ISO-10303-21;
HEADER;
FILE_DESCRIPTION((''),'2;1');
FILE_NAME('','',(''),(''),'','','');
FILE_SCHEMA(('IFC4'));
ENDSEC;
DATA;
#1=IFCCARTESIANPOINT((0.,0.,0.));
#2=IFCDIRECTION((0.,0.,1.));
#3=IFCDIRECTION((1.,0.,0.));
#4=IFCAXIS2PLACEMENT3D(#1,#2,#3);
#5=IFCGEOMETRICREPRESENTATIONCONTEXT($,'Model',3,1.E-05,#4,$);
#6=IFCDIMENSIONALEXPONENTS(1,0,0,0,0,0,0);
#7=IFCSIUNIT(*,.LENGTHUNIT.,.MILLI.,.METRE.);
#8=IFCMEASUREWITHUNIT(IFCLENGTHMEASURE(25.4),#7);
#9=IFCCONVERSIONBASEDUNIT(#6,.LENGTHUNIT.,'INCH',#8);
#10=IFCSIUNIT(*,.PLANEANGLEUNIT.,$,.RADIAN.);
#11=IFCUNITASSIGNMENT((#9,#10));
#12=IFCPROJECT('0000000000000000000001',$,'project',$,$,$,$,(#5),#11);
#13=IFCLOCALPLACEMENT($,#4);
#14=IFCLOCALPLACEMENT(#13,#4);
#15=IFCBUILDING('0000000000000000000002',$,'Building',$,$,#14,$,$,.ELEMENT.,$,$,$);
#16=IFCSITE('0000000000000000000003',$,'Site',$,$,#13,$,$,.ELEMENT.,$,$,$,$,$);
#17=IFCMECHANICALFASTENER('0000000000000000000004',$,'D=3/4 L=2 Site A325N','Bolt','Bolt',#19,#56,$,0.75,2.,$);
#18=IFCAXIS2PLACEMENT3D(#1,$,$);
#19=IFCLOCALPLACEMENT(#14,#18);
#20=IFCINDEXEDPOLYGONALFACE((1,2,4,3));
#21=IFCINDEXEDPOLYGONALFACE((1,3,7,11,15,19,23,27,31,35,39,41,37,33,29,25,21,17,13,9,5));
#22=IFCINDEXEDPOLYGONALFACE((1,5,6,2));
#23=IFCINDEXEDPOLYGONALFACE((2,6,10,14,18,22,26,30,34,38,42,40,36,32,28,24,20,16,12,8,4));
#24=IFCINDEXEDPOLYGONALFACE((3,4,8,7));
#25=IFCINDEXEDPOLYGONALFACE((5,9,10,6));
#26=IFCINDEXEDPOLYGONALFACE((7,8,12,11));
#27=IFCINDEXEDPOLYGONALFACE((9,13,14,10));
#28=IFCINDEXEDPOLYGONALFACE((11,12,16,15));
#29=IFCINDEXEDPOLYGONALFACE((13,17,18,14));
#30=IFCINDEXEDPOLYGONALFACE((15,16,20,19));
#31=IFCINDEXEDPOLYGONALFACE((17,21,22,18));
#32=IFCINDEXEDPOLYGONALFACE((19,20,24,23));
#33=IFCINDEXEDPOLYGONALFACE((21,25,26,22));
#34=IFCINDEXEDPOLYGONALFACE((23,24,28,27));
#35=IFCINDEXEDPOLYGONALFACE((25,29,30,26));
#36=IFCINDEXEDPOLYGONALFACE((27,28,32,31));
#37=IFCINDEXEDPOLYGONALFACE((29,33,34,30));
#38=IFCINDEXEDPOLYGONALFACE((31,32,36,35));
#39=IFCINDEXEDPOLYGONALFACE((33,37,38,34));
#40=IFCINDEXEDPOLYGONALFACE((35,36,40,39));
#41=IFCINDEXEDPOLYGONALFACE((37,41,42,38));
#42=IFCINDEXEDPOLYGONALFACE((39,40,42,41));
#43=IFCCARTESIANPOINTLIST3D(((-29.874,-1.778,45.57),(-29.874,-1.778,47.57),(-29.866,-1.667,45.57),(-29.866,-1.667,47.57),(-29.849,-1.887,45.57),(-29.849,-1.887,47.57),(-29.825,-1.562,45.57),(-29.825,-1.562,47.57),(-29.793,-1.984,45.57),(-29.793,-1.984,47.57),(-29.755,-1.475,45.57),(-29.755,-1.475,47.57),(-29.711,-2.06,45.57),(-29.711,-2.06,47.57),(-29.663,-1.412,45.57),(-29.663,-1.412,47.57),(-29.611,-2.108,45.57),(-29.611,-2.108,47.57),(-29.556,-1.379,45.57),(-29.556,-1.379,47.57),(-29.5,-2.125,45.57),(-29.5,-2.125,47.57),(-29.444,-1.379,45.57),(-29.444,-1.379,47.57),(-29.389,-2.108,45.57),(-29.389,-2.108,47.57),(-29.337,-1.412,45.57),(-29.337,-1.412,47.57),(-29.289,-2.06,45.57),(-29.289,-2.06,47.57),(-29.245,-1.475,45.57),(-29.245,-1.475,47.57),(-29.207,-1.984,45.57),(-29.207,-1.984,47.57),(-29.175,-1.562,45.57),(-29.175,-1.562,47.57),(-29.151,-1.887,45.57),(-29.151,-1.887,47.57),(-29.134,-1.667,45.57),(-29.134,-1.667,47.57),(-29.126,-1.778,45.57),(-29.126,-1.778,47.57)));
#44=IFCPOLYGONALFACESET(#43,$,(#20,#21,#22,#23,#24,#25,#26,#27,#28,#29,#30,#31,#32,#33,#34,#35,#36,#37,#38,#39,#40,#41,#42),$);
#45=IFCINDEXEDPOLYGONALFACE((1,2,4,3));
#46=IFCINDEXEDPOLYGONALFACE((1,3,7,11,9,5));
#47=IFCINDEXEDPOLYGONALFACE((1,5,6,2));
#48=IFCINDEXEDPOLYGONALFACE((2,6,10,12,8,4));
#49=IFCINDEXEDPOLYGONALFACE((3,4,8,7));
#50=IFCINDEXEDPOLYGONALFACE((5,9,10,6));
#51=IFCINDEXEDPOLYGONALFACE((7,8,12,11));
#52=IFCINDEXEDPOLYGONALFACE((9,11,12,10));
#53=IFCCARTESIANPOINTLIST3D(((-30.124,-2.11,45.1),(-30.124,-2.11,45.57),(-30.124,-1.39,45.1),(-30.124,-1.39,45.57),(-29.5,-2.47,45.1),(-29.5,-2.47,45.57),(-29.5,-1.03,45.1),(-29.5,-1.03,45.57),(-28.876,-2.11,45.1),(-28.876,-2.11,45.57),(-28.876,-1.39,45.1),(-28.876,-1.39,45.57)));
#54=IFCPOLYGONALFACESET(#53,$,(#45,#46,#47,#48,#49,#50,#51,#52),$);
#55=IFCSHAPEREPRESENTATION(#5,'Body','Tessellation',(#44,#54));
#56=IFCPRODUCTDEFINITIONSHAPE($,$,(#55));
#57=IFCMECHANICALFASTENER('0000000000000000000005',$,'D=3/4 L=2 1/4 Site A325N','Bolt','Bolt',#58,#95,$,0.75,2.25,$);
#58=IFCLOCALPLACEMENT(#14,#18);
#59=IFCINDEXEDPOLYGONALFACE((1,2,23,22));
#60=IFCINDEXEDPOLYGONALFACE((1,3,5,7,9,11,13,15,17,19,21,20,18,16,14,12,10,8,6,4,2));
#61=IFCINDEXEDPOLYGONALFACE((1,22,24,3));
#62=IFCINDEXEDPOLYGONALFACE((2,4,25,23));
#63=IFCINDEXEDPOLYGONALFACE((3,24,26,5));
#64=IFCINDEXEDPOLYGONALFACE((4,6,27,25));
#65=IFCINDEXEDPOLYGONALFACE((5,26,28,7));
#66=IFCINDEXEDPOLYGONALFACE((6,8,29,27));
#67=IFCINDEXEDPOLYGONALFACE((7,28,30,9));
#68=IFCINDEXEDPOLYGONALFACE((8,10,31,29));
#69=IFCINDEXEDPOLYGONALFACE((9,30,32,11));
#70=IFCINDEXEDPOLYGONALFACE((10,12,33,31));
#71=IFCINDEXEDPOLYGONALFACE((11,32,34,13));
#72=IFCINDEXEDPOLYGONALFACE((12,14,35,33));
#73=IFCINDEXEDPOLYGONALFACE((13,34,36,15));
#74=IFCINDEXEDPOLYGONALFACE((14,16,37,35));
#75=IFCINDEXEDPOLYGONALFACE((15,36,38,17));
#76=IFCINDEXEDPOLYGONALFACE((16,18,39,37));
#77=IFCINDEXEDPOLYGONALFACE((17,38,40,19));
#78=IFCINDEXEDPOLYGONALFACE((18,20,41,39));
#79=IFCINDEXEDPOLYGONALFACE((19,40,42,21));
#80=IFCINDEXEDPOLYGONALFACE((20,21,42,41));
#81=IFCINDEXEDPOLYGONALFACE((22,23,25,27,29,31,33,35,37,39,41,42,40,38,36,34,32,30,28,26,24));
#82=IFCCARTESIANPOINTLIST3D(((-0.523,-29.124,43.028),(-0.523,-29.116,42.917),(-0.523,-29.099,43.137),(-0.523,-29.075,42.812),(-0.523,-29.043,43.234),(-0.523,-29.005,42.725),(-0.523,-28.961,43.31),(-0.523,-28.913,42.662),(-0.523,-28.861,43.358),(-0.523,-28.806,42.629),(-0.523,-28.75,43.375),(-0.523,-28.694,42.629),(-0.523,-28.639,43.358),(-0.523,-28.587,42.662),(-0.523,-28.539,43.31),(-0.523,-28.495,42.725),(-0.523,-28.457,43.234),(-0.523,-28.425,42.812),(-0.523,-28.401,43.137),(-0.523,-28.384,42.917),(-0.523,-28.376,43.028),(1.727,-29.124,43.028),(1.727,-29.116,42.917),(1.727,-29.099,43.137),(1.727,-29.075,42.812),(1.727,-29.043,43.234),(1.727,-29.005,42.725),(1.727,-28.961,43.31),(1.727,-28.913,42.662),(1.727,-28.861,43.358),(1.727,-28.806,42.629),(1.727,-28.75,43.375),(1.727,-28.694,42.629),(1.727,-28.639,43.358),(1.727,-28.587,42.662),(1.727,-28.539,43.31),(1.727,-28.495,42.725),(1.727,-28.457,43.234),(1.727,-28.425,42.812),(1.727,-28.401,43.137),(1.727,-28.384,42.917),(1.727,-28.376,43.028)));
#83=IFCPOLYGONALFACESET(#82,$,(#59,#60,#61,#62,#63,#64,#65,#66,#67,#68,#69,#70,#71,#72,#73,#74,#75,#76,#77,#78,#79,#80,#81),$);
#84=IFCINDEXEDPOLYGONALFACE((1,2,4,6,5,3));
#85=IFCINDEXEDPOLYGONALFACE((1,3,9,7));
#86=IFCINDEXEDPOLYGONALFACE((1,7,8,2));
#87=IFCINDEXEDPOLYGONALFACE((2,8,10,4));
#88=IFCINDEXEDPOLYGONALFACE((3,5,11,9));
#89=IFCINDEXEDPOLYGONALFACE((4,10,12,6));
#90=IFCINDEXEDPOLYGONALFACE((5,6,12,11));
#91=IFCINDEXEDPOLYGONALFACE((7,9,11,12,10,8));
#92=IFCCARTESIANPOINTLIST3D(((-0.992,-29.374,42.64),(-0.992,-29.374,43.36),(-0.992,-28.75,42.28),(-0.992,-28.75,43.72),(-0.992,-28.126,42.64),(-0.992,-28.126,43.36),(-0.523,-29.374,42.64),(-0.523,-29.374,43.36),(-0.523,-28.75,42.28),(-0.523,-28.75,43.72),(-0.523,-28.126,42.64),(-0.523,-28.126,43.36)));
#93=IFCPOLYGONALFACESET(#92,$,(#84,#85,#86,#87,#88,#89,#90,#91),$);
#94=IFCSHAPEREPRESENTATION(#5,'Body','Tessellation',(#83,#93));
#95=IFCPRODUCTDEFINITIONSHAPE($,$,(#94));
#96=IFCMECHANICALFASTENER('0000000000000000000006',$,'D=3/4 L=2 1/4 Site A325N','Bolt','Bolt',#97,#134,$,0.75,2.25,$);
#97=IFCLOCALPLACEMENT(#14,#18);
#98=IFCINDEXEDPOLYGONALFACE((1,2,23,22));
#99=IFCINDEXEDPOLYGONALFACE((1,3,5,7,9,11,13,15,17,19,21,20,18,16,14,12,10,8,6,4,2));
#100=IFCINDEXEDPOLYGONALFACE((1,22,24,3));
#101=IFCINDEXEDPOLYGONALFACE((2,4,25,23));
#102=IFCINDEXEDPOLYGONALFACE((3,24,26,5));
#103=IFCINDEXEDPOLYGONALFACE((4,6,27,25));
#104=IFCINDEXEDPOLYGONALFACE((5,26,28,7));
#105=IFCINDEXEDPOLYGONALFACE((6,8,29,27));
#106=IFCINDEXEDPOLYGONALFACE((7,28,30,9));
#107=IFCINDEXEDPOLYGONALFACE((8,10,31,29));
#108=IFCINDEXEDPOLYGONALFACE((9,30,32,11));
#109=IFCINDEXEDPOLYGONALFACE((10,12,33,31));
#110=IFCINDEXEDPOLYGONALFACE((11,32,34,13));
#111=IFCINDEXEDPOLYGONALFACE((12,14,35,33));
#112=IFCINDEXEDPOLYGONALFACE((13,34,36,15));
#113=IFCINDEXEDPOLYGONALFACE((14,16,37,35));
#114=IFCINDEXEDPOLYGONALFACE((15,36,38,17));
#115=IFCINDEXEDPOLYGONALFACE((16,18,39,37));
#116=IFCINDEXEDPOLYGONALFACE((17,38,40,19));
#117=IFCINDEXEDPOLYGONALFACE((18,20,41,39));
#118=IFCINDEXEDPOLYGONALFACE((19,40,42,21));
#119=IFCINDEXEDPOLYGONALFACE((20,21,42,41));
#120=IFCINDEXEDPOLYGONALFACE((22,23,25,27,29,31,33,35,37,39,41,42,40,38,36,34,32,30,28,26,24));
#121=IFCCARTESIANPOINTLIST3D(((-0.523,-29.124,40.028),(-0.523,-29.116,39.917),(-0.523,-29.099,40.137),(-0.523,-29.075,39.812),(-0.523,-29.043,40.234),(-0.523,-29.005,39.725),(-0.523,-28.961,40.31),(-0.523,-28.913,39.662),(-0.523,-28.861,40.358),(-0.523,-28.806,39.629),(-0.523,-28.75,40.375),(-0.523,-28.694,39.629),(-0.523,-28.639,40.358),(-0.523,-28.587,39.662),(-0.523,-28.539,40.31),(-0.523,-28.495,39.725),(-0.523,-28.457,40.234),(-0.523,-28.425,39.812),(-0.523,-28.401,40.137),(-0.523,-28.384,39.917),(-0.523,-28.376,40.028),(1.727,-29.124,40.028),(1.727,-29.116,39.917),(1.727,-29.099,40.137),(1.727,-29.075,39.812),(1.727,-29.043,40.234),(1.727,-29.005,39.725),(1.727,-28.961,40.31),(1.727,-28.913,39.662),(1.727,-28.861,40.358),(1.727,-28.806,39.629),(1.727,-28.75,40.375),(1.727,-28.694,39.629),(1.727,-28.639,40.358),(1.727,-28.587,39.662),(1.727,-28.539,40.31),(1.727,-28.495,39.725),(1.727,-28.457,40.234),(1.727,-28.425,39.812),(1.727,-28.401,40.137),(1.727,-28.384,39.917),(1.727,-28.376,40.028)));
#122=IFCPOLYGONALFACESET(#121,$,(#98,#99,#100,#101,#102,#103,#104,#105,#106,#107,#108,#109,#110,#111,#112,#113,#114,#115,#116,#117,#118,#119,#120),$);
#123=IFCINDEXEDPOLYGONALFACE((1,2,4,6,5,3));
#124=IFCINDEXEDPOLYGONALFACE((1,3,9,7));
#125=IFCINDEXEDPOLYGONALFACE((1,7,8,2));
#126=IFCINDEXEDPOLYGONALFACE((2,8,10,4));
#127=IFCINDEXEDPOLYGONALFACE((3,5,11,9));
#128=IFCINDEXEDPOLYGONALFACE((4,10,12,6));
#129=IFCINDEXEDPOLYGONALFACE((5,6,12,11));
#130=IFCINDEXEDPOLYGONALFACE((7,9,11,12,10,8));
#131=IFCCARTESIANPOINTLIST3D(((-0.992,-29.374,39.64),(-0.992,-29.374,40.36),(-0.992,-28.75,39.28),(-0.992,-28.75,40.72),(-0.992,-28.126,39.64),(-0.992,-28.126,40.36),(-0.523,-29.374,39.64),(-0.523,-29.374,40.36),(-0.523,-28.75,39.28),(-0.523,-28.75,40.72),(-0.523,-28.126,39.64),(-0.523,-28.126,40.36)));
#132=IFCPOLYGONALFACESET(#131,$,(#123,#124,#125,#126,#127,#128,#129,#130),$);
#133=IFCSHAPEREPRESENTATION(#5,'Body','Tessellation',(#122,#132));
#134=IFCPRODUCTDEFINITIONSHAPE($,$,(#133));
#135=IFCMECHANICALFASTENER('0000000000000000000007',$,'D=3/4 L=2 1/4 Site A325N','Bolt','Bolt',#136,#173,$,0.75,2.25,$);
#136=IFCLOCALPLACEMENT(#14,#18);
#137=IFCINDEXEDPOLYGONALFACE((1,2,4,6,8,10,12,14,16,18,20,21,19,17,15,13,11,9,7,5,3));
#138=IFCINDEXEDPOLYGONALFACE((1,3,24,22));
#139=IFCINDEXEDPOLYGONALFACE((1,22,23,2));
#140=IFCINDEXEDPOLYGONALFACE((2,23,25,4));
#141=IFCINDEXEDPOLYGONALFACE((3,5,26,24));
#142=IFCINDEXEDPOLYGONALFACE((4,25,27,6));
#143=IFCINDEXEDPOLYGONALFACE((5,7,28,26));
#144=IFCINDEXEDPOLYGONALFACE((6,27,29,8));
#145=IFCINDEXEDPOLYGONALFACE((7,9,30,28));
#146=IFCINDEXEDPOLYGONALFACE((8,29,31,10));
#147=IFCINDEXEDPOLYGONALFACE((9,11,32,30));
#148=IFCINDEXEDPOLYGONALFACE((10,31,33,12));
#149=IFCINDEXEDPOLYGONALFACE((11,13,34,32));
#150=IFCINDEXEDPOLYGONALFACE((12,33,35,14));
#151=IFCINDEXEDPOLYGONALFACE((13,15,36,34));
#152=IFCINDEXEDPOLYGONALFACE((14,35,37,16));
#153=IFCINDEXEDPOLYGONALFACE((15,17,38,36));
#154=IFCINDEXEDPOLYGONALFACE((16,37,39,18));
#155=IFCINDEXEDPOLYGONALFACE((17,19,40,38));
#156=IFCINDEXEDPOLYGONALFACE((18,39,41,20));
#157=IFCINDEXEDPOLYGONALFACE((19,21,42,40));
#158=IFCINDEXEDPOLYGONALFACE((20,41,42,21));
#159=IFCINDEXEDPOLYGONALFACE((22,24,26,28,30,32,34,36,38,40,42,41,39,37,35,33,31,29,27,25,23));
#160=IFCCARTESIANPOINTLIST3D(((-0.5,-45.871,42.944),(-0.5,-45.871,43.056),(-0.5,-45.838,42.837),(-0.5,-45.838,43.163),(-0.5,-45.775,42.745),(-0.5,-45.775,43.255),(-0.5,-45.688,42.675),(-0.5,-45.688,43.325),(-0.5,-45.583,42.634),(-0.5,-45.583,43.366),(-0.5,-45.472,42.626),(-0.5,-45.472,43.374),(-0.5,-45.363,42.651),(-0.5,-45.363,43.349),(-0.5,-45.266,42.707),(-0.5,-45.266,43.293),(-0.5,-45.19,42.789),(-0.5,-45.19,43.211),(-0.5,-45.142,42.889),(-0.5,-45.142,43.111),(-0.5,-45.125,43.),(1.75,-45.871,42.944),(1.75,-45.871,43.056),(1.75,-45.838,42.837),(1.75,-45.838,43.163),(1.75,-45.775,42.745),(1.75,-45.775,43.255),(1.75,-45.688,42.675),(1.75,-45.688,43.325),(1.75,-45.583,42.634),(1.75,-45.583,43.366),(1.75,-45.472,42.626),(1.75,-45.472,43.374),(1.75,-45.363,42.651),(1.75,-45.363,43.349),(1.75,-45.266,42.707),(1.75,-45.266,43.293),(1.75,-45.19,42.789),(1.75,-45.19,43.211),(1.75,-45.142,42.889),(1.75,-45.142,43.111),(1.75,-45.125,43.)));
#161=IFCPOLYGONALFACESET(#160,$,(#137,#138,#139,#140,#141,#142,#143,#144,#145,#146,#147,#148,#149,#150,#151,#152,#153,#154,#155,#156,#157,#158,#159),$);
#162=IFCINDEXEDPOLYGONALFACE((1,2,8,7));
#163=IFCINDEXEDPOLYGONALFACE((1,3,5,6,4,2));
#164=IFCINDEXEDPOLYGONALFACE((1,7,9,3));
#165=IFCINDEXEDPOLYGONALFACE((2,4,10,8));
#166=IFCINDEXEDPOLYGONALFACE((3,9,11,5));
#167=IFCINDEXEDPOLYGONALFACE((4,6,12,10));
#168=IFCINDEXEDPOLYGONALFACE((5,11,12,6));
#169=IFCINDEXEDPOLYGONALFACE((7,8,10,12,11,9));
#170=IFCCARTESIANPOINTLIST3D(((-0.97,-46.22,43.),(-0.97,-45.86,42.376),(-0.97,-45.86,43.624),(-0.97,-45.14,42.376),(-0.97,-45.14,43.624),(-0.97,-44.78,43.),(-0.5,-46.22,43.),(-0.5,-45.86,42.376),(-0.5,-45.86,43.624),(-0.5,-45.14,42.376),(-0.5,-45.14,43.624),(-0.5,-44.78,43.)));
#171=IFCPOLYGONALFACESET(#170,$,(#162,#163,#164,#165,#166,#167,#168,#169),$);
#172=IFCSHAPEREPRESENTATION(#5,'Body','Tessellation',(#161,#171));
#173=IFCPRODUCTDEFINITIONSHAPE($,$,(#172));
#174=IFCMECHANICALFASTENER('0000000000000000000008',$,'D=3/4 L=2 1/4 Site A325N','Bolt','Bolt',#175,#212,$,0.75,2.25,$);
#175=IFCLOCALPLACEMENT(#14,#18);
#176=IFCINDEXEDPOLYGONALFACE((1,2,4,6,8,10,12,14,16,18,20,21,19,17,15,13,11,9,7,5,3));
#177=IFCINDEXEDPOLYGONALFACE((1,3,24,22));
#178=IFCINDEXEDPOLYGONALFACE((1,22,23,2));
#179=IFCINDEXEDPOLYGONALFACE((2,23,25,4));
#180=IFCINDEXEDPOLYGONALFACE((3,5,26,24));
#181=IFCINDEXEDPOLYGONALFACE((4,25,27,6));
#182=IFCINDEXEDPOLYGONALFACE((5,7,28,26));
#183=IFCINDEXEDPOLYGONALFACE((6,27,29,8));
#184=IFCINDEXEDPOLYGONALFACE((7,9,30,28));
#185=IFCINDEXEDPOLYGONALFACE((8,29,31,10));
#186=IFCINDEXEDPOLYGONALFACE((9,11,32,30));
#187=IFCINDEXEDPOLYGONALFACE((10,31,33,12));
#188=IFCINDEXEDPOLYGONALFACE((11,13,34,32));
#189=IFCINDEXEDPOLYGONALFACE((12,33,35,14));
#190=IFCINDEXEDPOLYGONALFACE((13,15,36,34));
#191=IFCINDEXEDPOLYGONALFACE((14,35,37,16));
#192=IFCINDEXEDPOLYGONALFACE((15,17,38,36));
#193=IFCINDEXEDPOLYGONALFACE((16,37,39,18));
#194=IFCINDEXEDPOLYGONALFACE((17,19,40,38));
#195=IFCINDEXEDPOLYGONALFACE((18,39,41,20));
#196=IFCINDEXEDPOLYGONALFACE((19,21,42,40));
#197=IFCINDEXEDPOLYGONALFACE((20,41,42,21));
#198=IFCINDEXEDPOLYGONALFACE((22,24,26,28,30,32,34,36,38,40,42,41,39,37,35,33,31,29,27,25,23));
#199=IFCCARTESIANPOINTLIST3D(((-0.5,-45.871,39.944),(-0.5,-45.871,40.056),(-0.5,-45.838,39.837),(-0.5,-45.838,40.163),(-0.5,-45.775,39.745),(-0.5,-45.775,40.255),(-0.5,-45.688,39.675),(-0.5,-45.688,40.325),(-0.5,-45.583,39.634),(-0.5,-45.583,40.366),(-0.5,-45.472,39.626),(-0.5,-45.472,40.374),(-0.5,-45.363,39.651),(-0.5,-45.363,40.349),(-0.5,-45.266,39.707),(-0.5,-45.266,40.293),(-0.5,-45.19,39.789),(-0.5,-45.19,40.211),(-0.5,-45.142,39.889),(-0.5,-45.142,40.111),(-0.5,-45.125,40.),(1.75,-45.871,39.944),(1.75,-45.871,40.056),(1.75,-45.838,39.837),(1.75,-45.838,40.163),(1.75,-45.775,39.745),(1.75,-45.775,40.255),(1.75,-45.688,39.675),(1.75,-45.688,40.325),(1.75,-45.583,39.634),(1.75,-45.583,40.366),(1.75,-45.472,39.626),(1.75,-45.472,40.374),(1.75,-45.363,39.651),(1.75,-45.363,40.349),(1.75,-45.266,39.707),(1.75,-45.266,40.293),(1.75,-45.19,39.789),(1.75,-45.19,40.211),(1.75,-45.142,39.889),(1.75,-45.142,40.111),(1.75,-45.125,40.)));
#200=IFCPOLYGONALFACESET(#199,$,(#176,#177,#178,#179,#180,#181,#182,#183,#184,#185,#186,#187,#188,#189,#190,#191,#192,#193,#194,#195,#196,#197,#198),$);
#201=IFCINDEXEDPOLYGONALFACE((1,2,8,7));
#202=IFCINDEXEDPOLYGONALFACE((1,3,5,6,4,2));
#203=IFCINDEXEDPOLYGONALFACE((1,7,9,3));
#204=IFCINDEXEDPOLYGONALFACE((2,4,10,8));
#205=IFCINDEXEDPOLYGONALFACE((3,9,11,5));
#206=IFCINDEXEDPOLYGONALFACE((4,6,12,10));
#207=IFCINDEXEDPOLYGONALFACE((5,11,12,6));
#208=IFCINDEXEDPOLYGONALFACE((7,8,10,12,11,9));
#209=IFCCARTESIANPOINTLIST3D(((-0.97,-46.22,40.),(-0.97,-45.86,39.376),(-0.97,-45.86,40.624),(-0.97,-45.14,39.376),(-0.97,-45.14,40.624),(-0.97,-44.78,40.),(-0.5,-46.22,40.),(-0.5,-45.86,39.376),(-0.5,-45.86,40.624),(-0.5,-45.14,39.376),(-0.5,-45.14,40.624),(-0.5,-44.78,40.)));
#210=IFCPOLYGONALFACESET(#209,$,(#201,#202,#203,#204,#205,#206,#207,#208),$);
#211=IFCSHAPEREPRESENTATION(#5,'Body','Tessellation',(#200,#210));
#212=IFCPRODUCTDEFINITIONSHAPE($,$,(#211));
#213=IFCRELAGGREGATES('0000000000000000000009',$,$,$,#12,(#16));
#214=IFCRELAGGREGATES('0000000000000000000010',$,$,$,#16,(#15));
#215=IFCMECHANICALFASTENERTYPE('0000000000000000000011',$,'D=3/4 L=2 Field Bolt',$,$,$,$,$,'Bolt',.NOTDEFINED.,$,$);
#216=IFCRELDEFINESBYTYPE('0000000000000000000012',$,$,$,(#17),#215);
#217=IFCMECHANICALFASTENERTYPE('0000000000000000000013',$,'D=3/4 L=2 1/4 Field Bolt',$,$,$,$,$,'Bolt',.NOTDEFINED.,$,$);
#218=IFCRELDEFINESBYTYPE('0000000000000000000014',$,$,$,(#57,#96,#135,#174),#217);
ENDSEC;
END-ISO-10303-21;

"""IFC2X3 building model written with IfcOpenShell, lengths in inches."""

from ifc_helpers import new_model, entity, si_unit, converted_unit, frame, origin_with_axes, origin_2d_with_axis, place, context, project, spatial, polyline, circle, outline, extrude, source, transform, mapped, type_object, type_shapes, element, save


model = new_model("IFC2X3")

# Units and contexts
model_context = context("Model", 3, precision=1e-05, world=origin_with_axes())
ifc_project = project(units=[converted_unit("LENGTHUNIT", "INCH", entity("IfcLengthMeasure", 25.4), si_unit("LENGTHUNIT", "METRE", prefix="MILLI"), dimensions=[1, 0, 0, 0, 0, 0, 0]), si_unit("PLANEANGLEUNIT", "RADIAN")], contexts=[model_context])

# Site, building
site_placement = place(None, origin_with_axes())
site = spatial("IfcSite", under=ifc_project, at=site_placement, Name="Site", CompositionType="ELEMENT")
building_placement = place(site_placement, origin_with_axes())
building = spatial("IfcBuilding", under=site, at=building_placement, Name="Building", CompositionType="ELEMENT")

# Mechanical fasteners
mechanical_fastener_type_1 = type_object("IfcMechanicalFastenerType", Name="D=3/4 L=2 Field Bolt", ElementType="Bolt")
shared_shape_1 = source(origin_with_axes(), model_context, "Body", "SweptSolid", [
    extrude(circle(Radius=0.375, at=origin_2d_with_axis()), frame((0.0, 0.0, 0.0), z_axis=(1.0, 0.0, 0.0), x_axis=(0.0, 1.0, 0.0)), (0.0, 0.0, 1.0), 2.0),
    extrude(outline(polyline([(-0.72, 0.0), (-0.36, 0.624), (0.36, 0.624), (0.72, 0.0), (0.36, -0.624), (-0.36, -0.624), (-0.72, 0.0)])), frame((0.0, 0.0, 0.0), z_axis=(1.0, 0.0, 0.0), x_axis=(0.0, 1.0, 0.0)), (0.0, 0.0, -1.0), 0.47),
])
type_shapes(mechanical_fastener_type_1, [shared_shape_1])
placement_1 = place(building_placement, frame((-33.0, 0.0, 46.0), z_axis=(-1.0, 0.0, 0.0), x_axis=(0.0, 0.0, 1.0)))
placement_2 = place(placement_1, frame((-0.43, 1.75, 3.5), z_axis=(0.0, 0.0, -1.0), x_axis=(1.0, 0.0, 0.0)))
mechanical_fastener_1_placement = place(placement_2, frame((0.0, 3.5, 7.0), z_axis=(0.0, 0.0, 1.0), x_axis=(1.0, 0.0, 0.0)))
element("IfcMechanicalFastener", 1, at=mechanical_fastener_1_placement, type_object=mechanical_fastener_type_1, Name="D=3/4 L=2 Site A325N", Description="Bolt", ObjectType="Bolt", NominalDiameter=0.75, NominalLength=2.0, context=model_context, shape_type="MappedRepresentation", body=[
    mapped(shared_shape_1, transform((0.0, 0.0, 0.0), scale=1.0)),
])
mechanical_fastener_type_2 = type_object("IfcMechanicalFastenerType", Name="D=3/4 L=2 1/4 Field Bolt", ElementType="Bolt")
shared_shape_2 = source(origin_with_axes(), model_context, "Body", "SweptSolid", [
    extrude(circle(Radius=0.375, at=origin_2d_with_axis()), frame((0.0, 0.0, 0.0), z_axis=(1.0, 0.0, 0.0), x_axis=(0.0, 1.0, 0.0)), (0.0, 0.0, 1.0), 2.25),
    extrude(outline(polyline([(-0.72, 0.0), (-0.36, 0.624), (0.36, 0.624), (0.72, 0.0), (0.36, -0.624), (-0.36, -0.624), (-0.72, 0.0)])), frame((0.0, 0.0, 0.0), z_axis=(1.0, 0.0, 0.0), x_axis=(0.0, 1.0, 0.0)), (0.0, 0.0, -1.0), 0.47),
])
type_shapes(mechanical_fastener_type_2, [shared_shape_2])
placement_3 = place(building_placement, frame((0.0, -27.0, 46.0), z_axis=(0.0, 0.0, 1.0), x_axis=(0.0, -1.0, 0.0)))
placement_4 = place(placement_3, frame((1.75, -0.523, -3.0), z_axis=(1.0, 0.0, 0.0), x_axis=(0.0, 1.0, 0.0)))
for number, where, z_axis, x_axis, name in (
    (2, (0.0, 0.0, 0.0), (0.0, 0.0, 1.0), (1.0, 0.0, 0.0), "D=3/4 L=2 1/4 Site A325N"),
    (3, (0.0, -3.0, 0.0), (0.0, 0.0, 1.0), (1.0, 0.0, 0.0), "D=3/4 L=2 1/4 Site A325N"),
):
    element("IfcMechanicalFastener", number, at=place(placement_4, frame(where, z_axis=z_axis, x_axis=x_axis)), type_object=mechanical_fastener_type_2, Name=name, Description="Bolt", ObjectType="Bolt", NominalDiameter=0.75, NominalLength=2.25, context=model_context, shape_type="MappedRepresentation", body=[
        mapped(shared_shape_2, transform((0.0, 0.0, 0.0), scale=1.0)),
    ])
placement_5 = place(building_placement, frame((0.0, -43.0, 46.0), z_axis=(0.0, 0.0, 1.0), x_axis=(1.0, 0.0, 0.0)))
placement_6 = place(placement_5, frame((-0.5, -2.5, -6.0), z_axis=(0.0, 0.0, 1.0), x_axis=(1.0, 0.0, 0.0)))
for number, where, z_axis, x_axis, name in (
    (4, (0.0, 0.0, 3.0), (0.0, 0.0, 1.0), (1.0, 0.0, 0.0), "D=3/4 L=2 1/4 Site A325N"),
    (5, (0.0, 0.0, 0.0), (0.0, 0.0, 1.0), (1.0, 0.0, 0.0), "D=3/4 L=2 1/4 Site A325N"),
):
    element("IfcMechanicalFastener", number, at=place(placement_6, frame(where, z_axis=z_axis, x_axis=x_axis)), type_object=mechanical_fastener_type_2, Name=name, Description="Bolt", ObjectType="Bolt", NominalDiameter=0.75, NominalLength=2.25, context=model_context, shape_type="MappedRepresentation", body=[
        mapped(shared_shape_2, transform((0.0, 0.0, 0.0), scale=1.0)),
    ])

save(model, "model.ifc")
